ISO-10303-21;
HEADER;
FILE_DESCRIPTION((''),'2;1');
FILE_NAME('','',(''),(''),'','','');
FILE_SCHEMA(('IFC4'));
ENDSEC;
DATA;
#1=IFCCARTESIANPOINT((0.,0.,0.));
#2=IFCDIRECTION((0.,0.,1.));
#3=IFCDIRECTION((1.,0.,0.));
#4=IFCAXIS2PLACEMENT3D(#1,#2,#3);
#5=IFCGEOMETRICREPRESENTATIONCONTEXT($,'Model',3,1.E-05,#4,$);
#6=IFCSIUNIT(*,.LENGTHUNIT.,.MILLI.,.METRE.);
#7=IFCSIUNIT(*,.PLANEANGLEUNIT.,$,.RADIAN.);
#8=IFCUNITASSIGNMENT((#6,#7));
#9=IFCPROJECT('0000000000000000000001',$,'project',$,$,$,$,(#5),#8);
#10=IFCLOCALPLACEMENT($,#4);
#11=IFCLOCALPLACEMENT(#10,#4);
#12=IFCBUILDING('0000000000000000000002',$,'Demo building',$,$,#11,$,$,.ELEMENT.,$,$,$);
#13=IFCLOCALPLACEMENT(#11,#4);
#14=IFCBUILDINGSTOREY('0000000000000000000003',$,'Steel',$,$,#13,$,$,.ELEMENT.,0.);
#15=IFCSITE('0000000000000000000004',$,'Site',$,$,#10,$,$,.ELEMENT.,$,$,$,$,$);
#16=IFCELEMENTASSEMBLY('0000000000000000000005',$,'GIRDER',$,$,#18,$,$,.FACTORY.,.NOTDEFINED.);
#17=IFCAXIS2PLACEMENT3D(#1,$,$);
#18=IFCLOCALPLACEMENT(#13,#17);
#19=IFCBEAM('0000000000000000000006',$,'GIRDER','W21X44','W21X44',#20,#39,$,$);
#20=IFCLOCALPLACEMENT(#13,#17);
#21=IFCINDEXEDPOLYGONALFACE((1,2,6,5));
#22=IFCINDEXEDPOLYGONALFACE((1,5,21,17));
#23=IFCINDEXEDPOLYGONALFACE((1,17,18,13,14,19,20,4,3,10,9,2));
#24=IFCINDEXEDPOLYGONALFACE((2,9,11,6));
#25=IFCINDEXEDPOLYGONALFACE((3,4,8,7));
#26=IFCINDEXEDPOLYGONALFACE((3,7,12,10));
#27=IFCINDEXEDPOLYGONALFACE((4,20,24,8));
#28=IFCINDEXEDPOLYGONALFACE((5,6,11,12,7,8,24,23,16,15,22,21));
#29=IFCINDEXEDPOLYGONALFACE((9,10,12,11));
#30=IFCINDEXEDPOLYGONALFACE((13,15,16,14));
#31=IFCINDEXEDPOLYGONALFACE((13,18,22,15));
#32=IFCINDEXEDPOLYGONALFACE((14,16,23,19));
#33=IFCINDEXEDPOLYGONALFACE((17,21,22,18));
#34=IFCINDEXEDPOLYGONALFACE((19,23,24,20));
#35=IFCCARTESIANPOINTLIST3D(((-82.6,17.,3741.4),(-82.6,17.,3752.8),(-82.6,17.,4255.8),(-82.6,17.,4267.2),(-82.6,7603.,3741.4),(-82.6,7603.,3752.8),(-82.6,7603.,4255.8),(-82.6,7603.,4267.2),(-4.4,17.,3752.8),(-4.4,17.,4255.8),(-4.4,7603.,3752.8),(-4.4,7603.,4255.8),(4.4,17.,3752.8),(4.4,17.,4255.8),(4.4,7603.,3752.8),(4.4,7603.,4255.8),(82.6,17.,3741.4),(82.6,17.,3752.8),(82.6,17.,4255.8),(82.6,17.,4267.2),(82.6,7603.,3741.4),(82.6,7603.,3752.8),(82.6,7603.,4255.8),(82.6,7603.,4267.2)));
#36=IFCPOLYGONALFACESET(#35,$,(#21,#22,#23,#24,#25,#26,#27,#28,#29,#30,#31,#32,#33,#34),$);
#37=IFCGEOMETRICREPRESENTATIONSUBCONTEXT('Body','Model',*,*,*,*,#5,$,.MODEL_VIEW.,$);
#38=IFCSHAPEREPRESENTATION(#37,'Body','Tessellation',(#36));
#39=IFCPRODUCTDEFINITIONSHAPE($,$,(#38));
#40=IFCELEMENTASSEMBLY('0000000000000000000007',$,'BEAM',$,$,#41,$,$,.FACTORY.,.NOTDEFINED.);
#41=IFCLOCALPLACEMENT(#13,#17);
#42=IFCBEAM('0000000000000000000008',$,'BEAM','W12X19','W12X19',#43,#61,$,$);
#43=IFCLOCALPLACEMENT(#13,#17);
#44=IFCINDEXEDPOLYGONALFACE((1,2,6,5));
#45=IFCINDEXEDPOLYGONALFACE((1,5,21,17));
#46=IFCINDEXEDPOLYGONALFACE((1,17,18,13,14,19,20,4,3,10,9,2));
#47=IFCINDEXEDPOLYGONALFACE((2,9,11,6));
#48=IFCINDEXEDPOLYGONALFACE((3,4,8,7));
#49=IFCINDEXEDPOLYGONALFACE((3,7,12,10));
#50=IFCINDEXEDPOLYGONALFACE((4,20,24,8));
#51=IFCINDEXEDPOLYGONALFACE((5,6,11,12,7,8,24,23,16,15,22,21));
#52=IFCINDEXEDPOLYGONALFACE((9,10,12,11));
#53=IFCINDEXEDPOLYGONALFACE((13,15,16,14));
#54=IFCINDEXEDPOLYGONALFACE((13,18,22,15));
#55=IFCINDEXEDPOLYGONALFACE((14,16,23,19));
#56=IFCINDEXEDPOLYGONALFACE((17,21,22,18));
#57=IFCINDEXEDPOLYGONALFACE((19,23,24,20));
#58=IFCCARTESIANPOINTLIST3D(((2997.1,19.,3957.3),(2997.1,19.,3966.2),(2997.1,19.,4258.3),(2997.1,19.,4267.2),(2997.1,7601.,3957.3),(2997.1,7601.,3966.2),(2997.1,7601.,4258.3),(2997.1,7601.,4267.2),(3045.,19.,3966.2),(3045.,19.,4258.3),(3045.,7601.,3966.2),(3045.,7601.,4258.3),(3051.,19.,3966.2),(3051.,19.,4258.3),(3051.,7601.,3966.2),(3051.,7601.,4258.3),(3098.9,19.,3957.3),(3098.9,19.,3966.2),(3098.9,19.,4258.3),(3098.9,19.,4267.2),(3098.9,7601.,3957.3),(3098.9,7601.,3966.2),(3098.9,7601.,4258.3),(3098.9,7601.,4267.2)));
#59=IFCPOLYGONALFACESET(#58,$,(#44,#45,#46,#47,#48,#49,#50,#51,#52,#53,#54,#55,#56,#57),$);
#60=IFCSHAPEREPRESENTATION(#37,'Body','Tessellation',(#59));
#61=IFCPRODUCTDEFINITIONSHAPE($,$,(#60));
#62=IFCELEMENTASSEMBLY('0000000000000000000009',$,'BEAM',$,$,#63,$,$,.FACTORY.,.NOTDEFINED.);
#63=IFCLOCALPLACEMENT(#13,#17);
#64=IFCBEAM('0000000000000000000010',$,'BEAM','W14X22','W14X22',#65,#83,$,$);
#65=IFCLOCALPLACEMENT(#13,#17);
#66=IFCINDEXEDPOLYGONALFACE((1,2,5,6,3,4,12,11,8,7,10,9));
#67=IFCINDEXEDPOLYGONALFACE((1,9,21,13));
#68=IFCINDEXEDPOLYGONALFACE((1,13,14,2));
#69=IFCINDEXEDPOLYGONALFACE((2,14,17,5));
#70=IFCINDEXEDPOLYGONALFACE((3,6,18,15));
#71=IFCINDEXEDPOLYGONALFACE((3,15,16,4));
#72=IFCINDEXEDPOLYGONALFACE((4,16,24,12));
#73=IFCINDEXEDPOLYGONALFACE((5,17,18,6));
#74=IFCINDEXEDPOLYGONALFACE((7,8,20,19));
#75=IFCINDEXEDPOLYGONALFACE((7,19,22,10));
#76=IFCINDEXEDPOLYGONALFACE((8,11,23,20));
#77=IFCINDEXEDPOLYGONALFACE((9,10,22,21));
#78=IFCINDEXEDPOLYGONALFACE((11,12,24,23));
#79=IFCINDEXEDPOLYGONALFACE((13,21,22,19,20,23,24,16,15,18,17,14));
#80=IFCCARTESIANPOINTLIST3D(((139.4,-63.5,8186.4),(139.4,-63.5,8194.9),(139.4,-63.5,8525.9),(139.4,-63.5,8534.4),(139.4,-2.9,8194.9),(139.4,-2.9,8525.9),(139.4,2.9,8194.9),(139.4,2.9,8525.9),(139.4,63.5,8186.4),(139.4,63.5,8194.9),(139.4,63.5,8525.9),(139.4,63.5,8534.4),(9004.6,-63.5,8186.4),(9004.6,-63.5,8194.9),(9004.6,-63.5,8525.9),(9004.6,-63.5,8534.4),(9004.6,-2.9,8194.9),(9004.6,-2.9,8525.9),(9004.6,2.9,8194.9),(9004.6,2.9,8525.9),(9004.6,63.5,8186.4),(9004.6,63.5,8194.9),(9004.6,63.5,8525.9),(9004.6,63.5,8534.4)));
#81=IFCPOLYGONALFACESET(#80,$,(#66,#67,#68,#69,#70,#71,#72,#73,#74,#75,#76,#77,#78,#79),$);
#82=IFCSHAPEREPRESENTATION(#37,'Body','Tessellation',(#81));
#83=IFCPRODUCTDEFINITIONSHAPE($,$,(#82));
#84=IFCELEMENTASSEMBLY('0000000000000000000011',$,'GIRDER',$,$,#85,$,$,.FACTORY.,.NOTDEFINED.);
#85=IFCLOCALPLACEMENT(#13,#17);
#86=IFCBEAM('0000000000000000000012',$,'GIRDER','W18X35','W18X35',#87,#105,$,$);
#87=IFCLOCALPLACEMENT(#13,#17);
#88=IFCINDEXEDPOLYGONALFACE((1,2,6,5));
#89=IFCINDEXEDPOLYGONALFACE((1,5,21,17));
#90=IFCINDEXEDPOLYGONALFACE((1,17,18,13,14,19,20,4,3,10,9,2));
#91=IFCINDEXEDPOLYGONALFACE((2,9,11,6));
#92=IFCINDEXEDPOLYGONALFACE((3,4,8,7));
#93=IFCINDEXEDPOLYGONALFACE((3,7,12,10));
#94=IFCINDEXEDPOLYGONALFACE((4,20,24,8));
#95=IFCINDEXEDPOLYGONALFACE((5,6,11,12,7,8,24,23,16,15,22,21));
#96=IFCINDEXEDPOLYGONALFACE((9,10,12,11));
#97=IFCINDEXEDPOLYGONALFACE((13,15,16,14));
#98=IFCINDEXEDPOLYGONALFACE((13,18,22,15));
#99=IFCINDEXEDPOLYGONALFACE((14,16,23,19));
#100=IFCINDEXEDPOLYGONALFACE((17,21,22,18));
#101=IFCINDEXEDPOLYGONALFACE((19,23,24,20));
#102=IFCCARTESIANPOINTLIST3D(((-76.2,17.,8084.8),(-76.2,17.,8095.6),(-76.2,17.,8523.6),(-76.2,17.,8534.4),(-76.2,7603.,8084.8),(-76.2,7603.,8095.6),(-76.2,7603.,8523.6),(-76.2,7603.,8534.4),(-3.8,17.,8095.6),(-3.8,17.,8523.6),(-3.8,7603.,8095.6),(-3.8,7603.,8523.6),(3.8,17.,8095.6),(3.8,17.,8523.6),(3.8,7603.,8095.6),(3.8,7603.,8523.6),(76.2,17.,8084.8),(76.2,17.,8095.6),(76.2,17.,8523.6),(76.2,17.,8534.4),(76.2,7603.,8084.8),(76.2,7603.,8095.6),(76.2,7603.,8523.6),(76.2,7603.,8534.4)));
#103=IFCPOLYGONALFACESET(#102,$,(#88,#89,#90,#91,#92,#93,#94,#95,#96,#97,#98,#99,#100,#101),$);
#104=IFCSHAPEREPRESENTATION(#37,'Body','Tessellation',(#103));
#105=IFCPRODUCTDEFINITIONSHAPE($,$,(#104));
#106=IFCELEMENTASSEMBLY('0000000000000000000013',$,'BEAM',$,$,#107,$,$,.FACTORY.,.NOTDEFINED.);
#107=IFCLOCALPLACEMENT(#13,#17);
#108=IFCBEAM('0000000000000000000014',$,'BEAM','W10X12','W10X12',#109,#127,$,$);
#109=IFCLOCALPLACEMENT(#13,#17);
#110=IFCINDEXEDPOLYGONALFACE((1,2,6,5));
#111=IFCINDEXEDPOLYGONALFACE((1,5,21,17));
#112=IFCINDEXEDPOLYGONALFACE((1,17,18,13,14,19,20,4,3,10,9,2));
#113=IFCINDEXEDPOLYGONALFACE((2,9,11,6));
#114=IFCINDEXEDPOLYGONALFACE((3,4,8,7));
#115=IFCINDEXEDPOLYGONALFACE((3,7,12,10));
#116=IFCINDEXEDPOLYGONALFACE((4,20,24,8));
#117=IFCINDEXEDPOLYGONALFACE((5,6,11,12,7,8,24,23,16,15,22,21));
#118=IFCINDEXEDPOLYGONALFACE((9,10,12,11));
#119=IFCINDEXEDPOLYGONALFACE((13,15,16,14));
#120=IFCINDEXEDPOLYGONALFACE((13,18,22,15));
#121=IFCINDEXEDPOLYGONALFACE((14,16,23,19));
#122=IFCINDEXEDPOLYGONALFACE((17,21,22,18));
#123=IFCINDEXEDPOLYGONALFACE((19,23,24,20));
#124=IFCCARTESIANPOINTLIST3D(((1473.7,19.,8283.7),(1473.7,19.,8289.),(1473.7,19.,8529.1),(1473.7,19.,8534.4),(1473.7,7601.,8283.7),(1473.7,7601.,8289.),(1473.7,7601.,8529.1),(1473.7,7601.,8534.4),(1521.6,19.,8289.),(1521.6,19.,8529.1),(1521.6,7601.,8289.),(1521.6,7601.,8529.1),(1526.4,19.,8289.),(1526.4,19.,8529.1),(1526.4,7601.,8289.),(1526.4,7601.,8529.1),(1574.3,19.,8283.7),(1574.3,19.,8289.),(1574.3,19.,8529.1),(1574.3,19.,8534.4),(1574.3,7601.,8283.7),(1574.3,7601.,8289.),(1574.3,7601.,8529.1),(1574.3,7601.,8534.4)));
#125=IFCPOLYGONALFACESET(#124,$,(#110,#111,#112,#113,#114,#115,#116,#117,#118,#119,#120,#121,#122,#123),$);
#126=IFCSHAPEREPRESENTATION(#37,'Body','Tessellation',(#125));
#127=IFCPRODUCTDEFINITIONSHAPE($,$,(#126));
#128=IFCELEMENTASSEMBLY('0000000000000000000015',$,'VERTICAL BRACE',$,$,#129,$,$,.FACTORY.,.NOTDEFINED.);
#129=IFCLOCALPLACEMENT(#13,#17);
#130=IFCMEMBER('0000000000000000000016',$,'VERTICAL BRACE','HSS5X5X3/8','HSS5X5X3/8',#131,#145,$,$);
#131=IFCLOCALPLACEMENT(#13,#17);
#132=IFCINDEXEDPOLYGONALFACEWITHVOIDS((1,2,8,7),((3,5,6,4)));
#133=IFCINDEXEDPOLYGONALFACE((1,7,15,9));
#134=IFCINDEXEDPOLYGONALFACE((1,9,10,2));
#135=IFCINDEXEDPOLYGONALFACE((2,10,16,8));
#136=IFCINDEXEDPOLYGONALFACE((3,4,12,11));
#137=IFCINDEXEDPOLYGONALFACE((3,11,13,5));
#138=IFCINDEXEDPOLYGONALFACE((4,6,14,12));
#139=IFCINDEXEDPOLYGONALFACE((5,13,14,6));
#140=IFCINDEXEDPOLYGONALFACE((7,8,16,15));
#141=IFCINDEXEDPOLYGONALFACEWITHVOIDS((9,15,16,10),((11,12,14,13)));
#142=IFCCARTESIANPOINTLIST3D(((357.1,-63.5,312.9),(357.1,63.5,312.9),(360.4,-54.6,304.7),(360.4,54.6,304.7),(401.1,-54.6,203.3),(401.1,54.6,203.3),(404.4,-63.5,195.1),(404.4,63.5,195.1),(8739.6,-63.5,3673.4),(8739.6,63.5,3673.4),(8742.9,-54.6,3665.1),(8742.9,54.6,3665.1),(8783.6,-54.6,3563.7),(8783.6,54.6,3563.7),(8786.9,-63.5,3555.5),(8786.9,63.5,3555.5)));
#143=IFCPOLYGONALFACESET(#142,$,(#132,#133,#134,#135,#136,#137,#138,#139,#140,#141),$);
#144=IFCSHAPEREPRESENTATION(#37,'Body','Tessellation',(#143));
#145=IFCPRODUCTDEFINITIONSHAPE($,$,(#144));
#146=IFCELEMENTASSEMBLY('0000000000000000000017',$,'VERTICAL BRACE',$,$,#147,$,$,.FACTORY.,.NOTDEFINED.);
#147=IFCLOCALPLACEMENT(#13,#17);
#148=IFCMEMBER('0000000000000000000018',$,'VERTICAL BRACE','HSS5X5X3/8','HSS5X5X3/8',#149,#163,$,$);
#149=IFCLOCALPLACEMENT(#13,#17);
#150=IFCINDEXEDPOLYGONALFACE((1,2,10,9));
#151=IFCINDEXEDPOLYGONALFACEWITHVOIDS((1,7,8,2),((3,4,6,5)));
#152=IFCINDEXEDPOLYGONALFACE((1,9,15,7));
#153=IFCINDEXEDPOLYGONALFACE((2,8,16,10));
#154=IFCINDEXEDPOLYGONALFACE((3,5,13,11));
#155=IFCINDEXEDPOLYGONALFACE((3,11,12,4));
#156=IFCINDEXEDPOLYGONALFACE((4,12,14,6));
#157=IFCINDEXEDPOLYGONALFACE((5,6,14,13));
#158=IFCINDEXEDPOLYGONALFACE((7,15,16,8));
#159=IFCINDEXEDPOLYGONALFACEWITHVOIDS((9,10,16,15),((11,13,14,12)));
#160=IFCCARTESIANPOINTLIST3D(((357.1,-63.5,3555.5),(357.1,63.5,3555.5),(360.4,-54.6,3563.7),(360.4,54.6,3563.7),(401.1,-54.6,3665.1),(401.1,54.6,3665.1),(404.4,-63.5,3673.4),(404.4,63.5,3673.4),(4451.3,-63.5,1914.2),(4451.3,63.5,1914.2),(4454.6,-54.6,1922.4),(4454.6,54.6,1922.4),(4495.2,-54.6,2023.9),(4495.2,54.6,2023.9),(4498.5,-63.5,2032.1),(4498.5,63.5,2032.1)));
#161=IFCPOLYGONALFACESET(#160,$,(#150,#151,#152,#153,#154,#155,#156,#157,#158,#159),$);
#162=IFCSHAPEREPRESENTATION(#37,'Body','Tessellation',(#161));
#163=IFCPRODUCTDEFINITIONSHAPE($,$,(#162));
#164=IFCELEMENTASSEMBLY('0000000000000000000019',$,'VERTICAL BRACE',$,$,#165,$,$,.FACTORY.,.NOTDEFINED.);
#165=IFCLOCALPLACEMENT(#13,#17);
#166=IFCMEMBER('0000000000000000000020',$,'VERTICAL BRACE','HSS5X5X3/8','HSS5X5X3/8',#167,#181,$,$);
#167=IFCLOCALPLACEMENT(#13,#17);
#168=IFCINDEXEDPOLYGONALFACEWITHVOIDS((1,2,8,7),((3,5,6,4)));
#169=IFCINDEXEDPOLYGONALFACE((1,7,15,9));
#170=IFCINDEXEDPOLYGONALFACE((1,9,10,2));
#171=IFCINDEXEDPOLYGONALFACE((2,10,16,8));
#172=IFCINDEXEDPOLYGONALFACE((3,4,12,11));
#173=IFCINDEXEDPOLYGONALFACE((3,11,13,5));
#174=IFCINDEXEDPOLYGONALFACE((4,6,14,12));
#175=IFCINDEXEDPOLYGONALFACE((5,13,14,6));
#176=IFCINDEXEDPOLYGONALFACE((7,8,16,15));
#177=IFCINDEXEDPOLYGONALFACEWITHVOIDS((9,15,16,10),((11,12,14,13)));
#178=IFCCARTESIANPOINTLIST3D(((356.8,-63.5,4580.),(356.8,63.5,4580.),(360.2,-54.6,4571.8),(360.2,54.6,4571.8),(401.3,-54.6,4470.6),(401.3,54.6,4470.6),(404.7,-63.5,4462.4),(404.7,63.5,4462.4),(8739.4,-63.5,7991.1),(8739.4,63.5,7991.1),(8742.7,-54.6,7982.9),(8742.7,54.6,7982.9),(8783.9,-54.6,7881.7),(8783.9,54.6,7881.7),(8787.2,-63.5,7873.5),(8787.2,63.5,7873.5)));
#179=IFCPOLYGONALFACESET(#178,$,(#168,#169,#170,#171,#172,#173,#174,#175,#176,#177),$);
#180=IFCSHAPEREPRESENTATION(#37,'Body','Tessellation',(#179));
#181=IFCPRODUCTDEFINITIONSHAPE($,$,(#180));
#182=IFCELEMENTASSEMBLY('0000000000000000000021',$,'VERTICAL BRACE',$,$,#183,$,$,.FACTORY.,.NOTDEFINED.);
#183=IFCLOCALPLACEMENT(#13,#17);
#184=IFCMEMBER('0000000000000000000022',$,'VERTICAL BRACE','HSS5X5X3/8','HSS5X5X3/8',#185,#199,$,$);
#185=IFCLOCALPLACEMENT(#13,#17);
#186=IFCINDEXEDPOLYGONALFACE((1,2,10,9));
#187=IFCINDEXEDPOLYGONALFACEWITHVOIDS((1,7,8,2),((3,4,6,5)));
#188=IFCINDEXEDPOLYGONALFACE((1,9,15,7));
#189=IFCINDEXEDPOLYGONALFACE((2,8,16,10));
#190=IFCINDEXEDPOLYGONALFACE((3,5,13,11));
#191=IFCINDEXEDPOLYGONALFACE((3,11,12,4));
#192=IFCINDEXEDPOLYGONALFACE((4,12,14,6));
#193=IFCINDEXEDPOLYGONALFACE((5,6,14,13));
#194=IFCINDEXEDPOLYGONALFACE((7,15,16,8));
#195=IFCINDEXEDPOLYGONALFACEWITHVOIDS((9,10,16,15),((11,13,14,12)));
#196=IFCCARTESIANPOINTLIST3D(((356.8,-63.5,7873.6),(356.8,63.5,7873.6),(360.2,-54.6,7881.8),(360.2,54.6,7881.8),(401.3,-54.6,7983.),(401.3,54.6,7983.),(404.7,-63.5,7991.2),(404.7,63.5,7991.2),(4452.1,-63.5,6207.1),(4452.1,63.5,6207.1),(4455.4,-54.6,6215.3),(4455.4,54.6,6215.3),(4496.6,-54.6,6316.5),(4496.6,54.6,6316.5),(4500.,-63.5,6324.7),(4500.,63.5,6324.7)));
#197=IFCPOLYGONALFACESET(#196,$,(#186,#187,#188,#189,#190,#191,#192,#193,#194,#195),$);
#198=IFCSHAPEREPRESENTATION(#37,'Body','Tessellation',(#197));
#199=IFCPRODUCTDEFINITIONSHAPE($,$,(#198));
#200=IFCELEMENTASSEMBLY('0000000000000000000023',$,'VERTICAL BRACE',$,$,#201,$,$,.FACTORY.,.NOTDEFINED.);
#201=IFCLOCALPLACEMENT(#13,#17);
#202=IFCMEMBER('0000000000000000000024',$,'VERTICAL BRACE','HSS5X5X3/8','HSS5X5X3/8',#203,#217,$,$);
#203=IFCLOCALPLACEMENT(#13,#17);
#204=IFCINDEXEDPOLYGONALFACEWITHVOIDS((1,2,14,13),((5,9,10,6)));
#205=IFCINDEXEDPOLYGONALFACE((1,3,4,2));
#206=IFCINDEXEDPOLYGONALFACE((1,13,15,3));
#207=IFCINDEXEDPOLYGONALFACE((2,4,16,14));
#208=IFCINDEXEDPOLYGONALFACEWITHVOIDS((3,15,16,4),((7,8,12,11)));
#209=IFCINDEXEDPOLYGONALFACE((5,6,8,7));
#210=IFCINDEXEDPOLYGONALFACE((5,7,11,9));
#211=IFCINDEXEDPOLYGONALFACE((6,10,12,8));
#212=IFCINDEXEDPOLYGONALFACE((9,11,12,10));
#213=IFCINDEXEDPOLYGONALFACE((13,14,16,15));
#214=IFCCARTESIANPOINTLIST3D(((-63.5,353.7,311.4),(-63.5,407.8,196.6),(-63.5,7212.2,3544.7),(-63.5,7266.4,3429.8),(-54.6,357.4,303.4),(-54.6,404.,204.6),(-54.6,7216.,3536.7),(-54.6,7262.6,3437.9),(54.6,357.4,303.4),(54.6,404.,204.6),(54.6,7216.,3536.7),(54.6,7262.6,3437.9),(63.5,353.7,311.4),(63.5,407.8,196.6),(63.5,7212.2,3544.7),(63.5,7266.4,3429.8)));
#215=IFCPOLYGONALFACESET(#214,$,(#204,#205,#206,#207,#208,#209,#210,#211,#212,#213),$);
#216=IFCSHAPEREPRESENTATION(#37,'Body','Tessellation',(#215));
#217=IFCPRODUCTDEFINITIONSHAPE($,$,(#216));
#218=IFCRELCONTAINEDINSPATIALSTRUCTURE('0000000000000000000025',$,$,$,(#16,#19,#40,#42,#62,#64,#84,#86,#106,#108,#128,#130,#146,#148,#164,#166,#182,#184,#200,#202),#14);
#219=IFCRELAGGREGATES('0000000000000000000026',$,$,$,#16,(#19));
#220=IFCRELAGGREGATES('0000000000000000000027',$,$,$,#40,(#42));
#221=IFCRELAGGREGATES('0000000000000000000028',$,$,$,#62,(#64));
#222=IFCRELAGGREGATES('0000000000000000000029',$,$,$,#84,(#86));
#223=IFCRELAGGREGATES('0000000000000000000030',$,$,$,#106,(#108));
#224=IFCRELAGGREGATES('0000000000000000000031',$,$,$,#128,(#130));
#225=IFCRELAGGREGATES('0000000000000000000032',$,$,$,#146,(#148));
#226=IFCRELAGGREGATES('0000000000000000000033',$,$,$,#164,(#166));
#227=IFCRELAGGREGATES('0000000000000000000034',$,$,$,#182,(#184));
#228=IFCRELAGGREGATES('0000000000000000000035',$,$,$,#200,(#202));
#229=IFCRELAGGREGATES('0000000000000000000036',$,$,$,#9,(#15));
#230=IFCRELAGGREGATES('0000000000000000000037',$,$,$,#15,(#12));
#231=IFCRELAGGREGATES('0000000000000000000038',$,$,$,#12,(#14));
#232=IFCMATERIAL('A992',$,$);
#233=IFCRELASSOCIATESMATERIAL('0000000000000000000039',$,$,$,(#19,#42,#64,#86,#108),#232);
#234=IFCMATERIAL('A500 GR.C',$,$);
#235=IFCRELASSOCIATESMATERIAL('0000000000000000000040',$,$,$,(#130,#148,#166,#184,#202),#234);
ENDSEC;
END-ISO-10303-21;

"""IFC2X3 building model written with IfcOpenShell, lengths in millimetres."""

from ifc_helpers import new_model, si_unit, frame, origin, origin_with_axes, origin_2d, place, context, subcontext, project, spatial, hollow_rectangle, i_section, extrude, material, element, aggregate, save


model = new_model("IFC2X3")

# Units and contexts
model_context = context("Model", 3, precision=1e-05, world=origin_with_axes())
body_context = subcontext(model_context, "Body", "Model", "MODEL_VIEW")
ifc_project = project(units=[si_unit("LENGTHUNIT", "METRE", prefix="MILLI"), si_unit("PLANEANGLEUNIT", "RADIAN")], contexts=[model_context])

# Site, building, storey
site_placement = place(None, origin_with_axes())
site = spatial("IfcSite", under=ifc_project, at=site_placement, Name="Site", CompositionType="ELEMENT")
building_placement = place(site_placement, origin_with_axes())
building = spatial("IfcBuilding", under=site, at=building_placement, Name="Demo building", CompositionType="ELEMENT")
placement = place(building_placement, origin_with_axes())
storey = spatial("IfcBuildingStorey", under=building, at=placement, Name="Steel", CompositionType="ELEMENT", Elevation=0.0)

# Shared definitions
ifc_material_1 = material(Name="A992")

# Element assemblies, beams
assembly_1 = element("IfcElementAssembly", 1, at=placement, inside=storey, Name="GIRDER", AssemblyPlace="FACTORY", PredefinedType="NOTDEFINED")
beam_1_placement = place(placement, frame((0.0, 17.0, 4004.3), z_axis=(0.0, 1.0, 0.0), x_axis=(-1.0, 0.0, 0.0)))
beam_1 = element("IfcBeam", 2, at=beam_1_placement, inside=storey, material=ifc_material_1, Name="GIRDER", Description="W21X44", ObjectType="W21X44", context=body_context, shape_type="SweptSolid", body=[
    extrude(i_section(OverallWidth=165.1, OverallDepth=525.8, WebThickness=8.9, FlangeThickness=11.4, at=origin_2d()), origin(), (0.0, 0.0, 1.0), 7586.0),
])
aggregate(assembly_1, [beam_1])
assembly_2 = element("IfcElementAssembly", 3, at=placement, inside=storey, Name="BEAM", AssemblyPlace="FACTORY", PredefinedType="NOTDEFINED")
beam_2_placement = place(placement, frame((3048.0, 19.1, 4112.3), z_axis=(0.0, 1.0, 0.0), x_axis=(-1.0, 0.0, 0.0)))
beam_2 = element("IfcBeam", 4, at=beam_2_placement, inside=storey, material=ifc_material_1, Name="BEAM", Description="W12X19", ObjectType="W12X19", context=body_context, shape_type="SweptSolid", body=[
    extrude(i_section(OverallWidth=101.9, OverallDepth=309.9, WebThickness=6.0, FlangeThickness=8.9, at=origin_2d()), origin(), (0.0, 0.0, 1.0), 7581.9),
])
aggregate(assembly_2, [beam_2])
assembly_3 = element("IfcElementAssembly", 5, at=placement, inside=storey, Name="BEAM", AssemblyPlace="FACTORY", PredefinedType="NOTDEFINED")
beam_3_placement = place(placement, frame((139.4, 0.0, 8360.4), z_axis=(1.0, 0.0, 0.0), x_axis=(0.0, 1.0, 0.0)))
beam_3 = element("IfcBeam", 6, at=beam_3_placement, inside=storey, material=ifc_material_1, Name="BEAM", Description="W14X22", ObjectType="W14X22", context=body_context, shape_type="SweptSolid", body=[
    extrude(i_section(OverallWidth=127.0, OverallDepth=348.0, WebThickness=5.8, FlangeThickness=8.5, at=origin_2d()), origin(), (0.0, 0.0, 1.0), 8865.1),
])
aggregate(assembly_3, [beam_3])
assembly_4 = element("IfcElementAssembly", 7, at=placement, inside=storey, Name="GIRDER", AssemblyPlace="FACTORY", PredefinedType="NOTDEFINED")
beam_4_placement = place(placement, frame((0.0, 17.0, 8309.6), z_axis=(0.0, 1.0, 0.0), x_axis=(-1.0, 0.0, 0.0)))
beam_4 = element("IfcBeam", 8, at=beam_4_placement, inside=storey, material=ifc_material_1, Name="GIRDER", Description="W18X35", ObjectType="W18X35", context=body_context, shape_type="SweptSolid", body=[
    extrude(i_section(OverallWidth=152.4, OverallDepth=449.6, WebThickness=7.6, FlangeThickness=10.8, at=origin_2d()), origin(), (0.0, 0.0, 1.0), 7586.0),
])
aggregate(assembly_4, [beam_4])
assembly_5 = element("IfcElementAssembly", 9, at=placement, inside=storey, Name="BEAM", AssemblyPlace="FACTORY", PredefinedType="NOTDEFINED")
beam_5_placement = place(placement, frame((1524.0, 19.1, 8409.1), z_axis=(0.0, 1.0, 0.0), x_axis=(-1.0, 0.0, 0.0)))
beam_5 = element("IfcBeam", 10, at=beam_5_placement, inside=storey, material=ifc_material_1, Name="BEAM", Description="W10X12", ObjectType="W10X12", context=body_context, shape_type="SweptSolid", body=[
    extrude(i_section(OverallWidth=100.6, OverallDepth=250.7, WebThickness=4.8, FlangeThickness=5.3, at=origin_2d()), origin(), (0.0, 0.0, 1.0), 7581.9),
])
aggregate(assembly_5, [beam_5])

# Element assemblies, members
assembly_6 = element("IfcElementAssembly", 11, at=placement, inside=storey, Name="VERTICAL BRACE", AssemblyPlace="FACTORY", PredefinedType="NOTDEFINED")
ifc_material_2 = material(Name="A500 GR.C")
member_1_placement = place(placement, frame((380.7, 0.0, 254.0), z_axis=(0.9282, 0.0, 0.3721), x_axis=(0.0, 1.0, 0.0)))
member_1 = element("IfcMember", 12, at=member_1_placement, inside=storey, material=ifc_material_2, Name="VERTICAL BRACE", Description="HSS5X5X3/8", ObjectType="HSS5X5X3/8", context=body_context, shape_type="SweptSolid", body=[
    extrude(hollow_rectangle(XDim=127.0, YDim=127.0, WallThickness=8.9, at=origin_2d()), origin(), (0.0, 0.0, 1.0), 9031.0),
])
aggregate(assembly_6, [member_1])
assembly_7 = element("IfcElementAssembly", 13, at=placement, inside=storey, Name="VERTICAL BRACE", AssemblyPlace="FACTORY", PredefinedType="NOTDEFINED")
member_2_placement = place(placement, frame((380.7, 0.0, 3614.4), z_axis=(0.9282, 0.0, -0.3721), x_axis=(0.0, 1.0, 0.0)))
member_2 = element("IfcMember", 14, at=member_2_placement, inside=storey, material=ifc_material_2, Name="VERTICAL BRACE", Description="HSS5X5X3/8", ObjectType="HSS5X5X3/8", context=body_context, shape_type="SweptSolid", body=[
    extrude(hollow_rectangle(XDim=127.0, YDim=127.0, WallThickness=8.9, at=origin_2d()), origin(), (0.0, 0.0, 1.0), 4410.9),
])
aggregate(assembly_7, [member_2])
assembly_8 = element("IfcElementAssembly", 15, at=placement, inside=storey, Name="VERTICAL BRACE", AssemblyPlace="FACTORY", PredefinedType="NOTDEFINED")
member_3_placement = place(placement, frame((380.7, 0.0, 4521.2), z_axis=(0.9262, 0.0, 0.3769), x_axis=(0.0, 1.0, 0.0)))
member_3 = element("IfcMember", 16, at=member_3_placement, inside=storey, material=ifc_material_2, Name="VERTICAL BRACE", Description="HSS5X5X3/8", ObjectType="HSS5X5X3/8", context=body_context, shape_type="SweptSolid", body=[
    extrude(hollow_rectangle(XDim=127.0, YDim=127.0, WallThickness=8.9, at=origin_2d()), origin(), (0.0, 0.0, 1.0), 9050.0),
])
aggregate(assembly_8, [member_3])
assembly_9 = element("IfcElementAssembly", 17, at=placement, inside=storey, Name="VERTICAL BRACE", AssemblyPlace="FACTORY", PredefinedType="NOTDEFINED")
member_4_placement = place(placement, frame((380.7, 0.0, 7932.4), z_axis=(0.9262, 0.0, -0.3769), x_axis=(0.0, 1.0, 0.0)))
member_4 = element("IfcMember", 18, at=member_4_placement, inside=storey, material=ifc_material_2, Name="VERTICAL BRACE", Description="HSS5X5X3/8", ObjectType="HSS5X5X3/8", context=body_context, shape_type="SweptSolid", body=[
    extrude(hollow_rectangle(XDim=127.0, YDim=127.0, WallThickness=8.9, at=origin_2d()), origin(), (0.0, 0.0, 1.0), 4421.4),
])
aggregate(assembly_9, [member_4])
assembly_10 = element("IfcElementAssembly", 19, at=placement, inside=storey, Name="VERTICAL BRACE", AssemblyPlace="FACTORY", PredefinedType="NOTDEFINED")
member_5_placement = place(placement, frame((0.0, 380.7, 254.0), z_axis=(0.0, 0.9045, 0.4264), x_axis=(-1.0, 0.0, 0.0)))
member_5 = element("IfcMember", 20, at=member_5_placement, inside=storey, material=ifc_material_2, Name="VERTICAL BRACE", Description="HSS5X5X3/8", ObjectType="HSS5X5X3/8", context=body_context, shape_type="SweptSolid", body=[
    extrude(hollow_rectangle(XDim=127.0, YDim=127.0, WallThickness=8.9, at=origin_2d()), origin(), (0.0, 0.0, 1.0), 7582.5),
])
aggregate(assembly_10, [member_5])

save(model, "model.ifc")
